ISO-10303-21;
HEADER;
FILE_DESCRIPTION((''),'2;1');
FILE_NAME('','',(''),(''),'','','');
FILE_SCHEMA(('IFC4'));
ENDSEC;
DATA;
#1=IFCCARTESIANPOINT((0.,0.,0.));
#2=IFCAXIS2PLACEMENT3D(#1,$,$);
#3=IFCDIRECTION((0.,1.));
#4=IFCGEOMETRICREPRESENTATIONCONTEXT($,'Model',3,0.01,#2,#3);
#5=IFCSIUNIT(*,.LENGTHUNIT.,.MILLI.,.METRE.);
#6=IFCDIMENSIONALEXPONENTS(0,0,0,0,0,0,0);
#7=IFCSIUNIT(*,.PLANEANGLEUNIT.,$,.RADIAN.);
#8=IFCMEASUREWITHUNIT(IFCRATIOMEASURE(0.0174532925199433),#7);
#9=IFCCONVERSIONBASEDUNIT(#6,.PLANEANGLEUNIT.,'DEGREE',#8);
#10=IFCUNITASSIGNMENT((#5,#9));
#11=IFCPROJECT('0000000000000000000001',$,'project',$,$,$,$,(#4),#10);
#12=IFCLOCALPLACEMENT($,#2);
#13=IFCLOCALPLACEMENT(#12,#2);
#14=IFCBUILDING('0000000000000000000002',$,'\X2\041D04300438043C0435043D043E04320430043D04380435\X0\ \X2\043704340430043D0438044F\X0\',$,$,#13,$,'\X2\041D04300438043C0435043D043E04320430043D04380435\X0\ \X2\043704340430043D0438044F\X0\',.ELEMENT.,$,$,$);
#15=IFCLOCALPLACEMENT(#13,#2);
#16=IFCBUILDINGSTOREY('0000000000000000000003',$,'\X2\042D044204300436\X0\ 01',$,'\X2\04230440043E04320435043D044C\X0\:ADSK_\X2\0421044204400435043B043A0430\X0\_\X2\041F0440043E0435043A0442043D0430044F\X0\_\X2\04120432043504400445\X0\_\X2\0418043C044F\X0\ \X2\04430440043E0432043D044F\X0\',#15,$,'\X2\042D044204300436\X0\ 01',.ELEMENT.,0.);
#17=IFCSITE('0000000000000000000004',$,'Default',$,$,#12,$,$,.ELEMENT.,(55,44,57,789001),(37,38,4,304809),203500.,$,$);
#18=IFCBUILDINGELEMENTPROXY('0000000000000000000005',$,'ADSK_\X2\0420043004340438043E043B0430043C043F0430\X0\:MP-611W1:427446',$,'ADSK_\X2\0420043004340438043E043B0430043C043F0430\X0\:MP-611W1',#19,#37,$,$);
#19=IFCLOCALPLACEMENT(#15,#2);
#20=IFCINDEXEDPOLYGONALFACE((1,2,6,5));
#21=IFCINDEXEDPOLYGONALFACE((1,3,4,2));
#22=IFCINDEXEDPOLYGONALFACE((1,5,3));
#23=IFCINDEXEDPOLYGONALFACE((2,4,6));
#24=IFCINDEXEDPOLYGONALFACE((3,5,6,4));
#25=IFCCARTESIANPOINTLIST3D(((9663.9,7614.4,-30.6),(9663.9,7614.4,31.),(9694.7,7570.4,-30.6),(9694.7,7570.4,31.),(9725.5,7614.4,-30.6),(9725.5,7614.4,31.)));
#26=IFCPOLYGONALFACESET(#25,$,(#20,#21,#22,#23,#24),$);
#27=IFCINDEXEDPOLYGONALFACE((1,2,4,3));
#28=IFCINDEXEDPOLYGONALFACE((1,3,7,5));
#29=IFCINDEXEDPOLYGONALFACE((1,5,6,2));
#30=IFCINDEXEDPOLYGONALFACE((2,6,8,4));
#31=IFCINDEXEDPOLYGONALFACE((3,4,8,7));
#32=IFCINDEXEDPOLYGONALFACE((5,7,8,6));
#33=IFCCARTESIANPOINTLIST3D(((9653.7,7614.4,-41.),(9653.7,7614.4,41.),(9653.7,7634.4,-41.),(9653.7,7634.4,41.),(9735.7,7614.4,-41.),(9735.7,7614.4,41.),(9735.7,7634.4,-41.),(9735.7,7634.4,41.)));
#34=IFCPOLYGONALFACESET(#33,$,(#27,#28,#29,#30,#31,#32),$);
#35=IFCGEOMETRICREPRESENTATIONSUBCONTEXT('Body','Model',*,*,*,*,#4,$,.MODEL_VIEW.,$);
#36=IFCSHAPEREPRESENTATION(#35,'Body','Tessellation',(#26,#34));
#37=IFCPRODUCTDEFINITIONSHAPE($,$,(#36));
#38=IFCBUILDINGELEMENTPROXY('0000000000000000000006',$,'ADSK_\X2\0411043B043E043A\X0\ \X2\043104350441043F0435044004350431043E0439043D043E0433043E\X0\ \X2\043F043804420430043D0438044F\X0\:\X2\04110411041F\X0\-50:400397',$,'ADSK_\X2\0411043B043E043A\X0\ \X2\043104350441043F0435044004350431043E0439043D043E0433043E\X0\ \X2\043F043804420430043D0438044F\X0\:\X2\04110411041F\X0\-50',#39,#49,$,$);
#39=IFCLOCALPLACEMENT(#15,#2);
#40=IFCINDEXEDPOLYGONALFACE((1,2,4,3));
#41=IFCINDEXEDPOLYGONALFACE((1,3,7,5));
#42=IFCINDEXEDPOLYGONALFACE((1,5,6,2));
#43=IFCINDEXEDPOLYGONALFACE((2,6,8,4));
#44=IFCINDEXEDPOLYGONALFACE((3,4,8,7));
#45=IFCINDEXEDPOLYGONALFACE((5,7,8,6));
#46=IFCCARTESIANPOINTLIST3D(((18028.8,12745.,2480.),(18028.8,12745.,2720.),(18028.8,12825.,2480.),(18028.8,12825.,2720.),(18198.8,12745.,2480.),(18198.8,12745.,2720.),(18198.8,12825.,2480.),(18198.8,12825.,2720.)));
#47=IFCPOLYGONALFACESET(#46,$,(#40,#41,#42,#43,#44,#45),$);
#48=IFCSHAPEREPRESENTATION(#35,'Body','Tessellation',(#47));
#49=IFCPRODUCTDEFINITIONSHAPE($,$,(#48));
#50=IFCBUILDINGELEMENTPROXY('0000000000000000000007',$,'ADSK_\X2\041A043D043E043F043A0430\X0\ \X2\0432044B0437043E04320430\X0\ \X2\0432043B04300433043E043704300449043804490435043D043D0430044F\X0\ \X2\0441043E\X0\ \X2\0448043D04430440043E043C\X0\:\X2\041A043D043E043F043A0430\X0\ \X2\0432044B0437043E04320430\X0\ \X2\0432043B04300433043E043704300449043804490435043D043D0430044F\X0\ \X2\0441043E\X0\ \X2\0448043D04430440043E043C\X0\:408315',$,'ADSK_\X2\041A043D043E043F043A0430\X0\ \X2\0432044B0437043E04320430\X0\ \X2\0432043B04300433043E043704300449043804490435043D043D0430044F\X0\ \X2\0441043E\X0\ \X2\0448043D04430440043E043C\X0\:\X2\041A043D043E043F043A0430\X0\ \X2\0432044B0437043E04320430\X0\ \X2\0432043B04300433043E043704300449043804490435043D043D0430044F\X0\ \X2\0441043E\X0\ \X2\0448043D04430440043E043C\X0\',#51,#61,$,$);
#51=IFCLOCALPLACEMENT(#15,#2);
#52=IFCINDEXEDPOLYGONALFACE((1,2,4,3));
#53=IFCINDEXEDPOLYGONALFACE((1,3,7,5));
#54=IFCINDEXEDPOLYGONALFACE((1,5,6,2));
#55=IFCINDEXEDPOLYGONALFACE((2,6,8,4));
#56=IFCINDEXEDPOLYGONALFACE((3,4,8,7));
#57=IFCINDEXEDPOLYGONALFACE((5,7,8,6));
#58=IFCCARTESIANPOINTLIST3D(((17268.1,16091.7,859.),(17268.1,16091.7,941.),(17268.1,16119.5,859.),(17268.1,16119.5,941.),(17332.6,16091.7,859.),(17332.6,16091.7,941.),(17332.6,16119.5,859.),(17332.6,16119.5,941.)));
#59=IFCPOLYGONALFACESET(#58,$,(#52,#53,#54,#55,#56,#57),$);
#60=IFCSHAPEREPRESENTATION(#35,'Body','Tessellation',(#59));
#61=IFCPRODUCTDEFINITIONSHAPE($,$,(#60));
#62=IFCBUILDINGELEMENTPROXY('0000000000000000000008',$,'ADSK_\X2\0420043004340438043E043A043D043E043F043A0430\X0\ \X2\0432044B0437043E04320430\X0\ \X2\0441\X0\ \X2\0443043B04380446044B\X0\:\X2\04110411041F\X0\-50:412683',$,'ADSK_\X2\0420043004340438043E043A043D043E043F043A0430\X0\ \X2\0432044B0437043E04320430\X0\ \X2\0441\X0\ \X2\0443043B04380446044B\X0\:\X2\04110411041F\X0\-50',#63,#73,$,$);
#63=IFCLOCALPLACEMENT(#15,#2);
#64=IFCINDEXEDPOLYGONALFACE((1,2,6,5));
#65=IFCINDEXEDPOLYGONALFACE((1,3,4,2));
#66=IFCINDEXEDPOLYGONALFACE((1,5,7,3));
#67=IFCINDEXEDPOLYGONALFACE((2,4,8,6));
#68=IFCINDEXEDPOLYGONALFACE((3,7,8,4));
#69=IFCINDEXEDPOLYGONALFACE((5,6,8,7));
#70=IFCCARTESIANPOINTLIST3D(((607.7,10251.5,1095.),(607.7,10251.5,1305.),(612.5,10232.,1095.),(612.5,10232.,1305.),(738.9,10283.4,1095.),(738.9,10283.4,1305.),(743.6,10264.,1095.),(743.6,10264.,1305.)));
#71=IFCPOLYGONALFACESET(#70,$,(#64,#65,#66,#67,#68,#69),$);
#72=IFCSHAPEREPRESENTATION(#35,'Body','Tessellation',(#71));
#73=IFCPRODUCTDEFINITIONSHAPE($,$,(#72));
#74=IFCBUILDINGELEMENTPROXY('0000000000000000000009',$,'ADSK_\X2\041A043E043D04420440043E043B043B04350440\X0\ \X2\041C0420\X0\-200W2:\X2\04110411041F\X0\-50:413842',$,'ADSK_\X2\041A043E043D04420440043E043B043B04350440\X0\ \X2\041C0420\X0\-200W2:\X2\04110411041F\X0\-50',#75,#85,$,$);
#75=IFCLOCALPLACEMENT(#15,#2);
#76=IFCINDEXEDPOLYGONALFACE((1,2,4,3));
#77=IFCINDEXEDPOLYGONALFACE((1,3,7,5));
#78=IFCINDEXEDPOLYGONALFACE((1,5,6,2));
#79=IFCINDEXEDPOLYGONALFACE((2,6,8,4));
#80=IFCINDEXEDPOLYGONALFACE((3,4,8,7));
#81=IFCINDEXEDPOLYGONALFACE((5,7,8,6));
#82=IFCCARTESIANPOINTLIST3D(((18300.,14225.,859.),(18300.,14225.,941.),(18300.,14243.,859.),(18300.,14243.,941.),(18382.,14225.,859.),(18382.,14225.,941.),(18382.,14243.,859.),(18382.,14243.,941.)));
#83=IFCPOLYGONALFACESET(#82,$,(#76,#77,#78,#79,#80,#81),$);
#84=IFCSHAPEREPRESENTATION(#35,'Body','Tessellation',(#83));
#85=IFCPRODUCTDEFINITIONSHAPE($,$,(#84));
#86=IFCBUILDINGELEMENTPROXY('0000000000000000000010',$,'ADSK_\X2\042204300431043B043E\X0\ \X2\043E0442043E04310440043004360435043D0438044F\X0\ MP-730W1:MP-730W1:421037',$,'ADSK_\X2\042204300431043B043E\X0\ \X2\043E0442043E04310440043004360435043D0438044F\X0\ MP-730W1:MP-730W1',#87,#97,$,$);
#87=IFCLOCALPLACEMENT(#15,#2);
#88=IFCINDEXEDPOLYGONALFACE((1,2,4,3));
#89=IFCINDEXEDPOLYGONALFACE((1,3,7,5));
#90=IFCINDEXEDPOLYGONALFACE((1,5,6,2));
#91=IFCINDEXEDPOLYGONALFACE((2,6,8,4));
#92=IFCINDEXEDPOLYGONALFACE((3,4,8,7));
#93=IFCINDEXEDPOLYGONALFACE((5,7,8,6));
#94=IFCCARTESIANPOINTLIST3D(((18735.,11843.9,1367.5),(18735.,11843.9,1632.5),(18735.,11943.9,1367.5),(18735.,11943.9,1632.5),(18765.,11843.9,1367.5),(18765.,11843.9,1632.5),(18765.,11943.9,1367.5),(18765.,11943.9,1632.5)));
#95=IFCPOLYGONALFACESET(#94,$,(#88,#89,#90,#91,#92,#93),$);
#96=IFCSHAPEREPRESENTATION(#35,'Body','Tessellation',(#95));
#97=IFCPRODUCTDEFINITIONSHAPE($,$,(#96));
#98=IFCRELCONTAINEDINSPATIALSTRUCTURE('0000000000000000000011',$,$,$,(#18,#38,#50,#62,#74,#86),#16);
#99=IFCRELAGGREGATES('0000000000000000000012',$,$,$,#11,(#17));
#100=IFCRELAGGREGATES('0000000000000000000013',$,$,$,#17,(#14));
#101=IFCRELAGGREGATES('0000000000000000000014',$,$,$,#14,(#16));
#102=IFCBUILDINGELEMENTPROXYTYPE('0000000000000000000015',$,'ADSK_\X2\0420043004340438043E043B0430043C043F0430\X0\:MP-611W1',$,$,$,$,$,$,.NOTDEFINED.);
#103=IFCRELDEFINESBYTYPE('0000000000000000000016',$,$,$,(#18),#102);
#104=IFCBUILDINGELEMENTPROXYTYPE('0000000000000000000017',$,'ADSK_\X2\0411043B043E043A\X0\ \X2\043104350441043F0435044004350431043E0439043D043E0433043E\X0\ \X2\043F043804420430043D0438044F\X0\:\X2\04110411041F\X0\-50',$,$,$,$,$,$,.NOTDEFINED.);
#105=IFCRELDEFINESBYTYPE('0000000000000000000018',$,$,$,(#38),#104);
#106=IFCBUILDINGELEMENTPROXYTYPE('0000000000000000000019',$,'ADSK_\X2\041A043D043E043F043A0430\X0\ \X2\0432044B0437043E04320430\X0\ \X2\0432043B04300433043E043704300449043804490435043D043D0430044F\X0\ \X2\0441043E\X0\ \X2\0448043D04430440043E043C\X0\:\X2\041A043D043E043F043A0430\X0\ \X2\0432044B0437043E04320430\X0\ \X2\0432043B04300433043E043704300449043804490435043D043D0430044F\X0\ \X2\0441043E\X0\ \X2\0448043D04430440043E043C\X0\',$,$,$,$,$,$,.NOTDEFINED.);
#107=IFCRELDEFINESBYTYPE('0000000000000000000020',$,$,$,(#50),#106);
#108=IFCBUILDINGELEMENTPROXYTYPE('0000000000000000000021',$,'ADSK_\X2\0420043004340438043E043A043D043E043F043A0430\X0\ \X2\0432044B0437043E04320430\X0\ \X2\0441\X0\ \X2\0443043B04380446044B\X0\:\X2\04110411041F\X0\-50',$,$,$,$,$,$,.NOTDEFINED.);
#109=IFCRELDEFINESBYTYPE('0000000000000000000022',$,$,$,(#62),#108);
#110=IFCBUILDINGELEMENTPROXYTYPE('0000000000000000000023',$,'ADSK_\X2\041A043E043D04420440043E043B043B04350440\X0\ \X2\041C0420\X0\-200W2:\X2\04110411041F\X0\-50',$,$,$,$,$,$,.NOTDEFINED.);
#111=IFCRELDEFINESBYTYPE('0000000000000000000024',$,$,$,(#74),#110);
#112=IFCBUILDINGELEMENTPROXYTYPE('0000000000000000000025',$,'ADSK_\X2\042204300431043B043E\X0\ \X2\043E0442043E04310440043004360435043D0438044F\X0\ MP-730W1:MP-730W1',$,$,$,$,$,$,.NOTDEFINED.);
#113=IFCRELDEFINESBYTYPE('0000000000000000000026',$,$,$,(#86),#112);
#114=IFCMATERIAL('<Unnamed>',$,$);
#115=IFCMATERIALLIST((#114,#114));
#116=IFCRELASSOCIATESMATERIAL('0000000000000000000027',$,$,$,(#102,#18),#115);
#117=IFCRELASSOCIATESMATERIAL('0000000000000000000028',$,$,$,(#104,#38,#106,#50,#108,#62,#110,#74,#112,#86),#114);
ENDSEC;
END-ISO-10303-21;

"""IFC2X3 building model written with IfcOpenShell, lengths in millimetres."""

from ifc_helpers import new_model, entity, si_unit, converted_unit, direction, frame, origin, origin_2d_with_axis, place, context, subcontext, project, spatial, polyline, rectangle, outline, extrude, source, transform, mapped, material, material_list, type_object, type_shapes, element, save


model = new_model("IFC2X3")

# Units and contexts
model_context = context("Model", 3, precision=0.01, world=origin(), true_north=direction((0.0, 1.0)))
body_context = subcontext(model_context, "Body", "Model", "MODEL_VIEW")
ifc_project = project(units=[si_unit("LENGTHUNIT", "METRE", prefix="MILLI"), converted_unit("PLANEANGLEUNIT", "DEGREE", entity("IfcRatioMeasure", 0.0174532925199433), si_unit("PLANEANGLEUNIT", "RADIAN"), dimensions=[0, 0, 0, 0, 0, 0, 0])], contexts=[model_context])

# Site, building, storey
site_placement = place(None, origin())
site = spatial("IfcSite", under=ifc_project, at=site_placement, Name="Default", CompositionType="ELEMENT", RefLatitude=(55, 44, 57, 789001), RefLongitude=(37, 38, 4, 304809), RefElevation=203500.0)
building_placement = place(site_placement, origin())
building = spatial("IfcBuilding", under=site, at=building_placement, Name="Наименование здания", LongName="Наименование здания", CompositionType="ELEMENT")
storey_placement = place(building_placement, origin())
storey = spatial("IfcBuildingStorey", under=building, at=storey_placement, Name="Этаж 01", ObjectType="Уровень:ADSK_Стрелка_Проектная_Вверх_Имя уровня", LongName="Этаж 01", CompositionType="ELEMENT", Elevation=0.0)

# Building element proxies
ifc_material_1 = material(Name="<Unnamed>")
ifc_material_list_1 = material_list([ifc_material_1, ifc_material_1])
shared_shape_1 = source(origin(), body_context, "Body", "SweptSolid", [
    extrude(outline(polyline([(-30.8, -14.7), (30.8, -14.7), (0.0, 29.3), (-30.8, -14.7)])), frame((0.0, -2.7, -30.6), z_axis=(0.0, 0.0, 1.0), x_axis=(-1.0, 0.0, 0.0)), (0.0, 0.0, 1.0), 61.6),
    extrude(rectangle(XDim=82.0, YDim=20.0, at=origin_2d_with_axis()), frame((0.0, 22.0, -41.0), z_axis=(0.0, 0.0, 1.0), x_axis=(-1.0, 0.0, 0.0)), (0.0, 0.0, 1.0), 82.0),
])
building_element_proxy_type_1 = type_object("IfcBuildingElementProxyType", Name="ADSK_Радиолампа:MP-611W1", PredefinedType="NOTDEFINED", material=ifc_material_list_1)
type_shapes(building_element_proxy_type_1, [shared_shape_1])
proxy_1_placement = place(storey_placement, frame((9694.7, 7602.4, 0.0)))
element("IfcBuildingElementProxy", 1, at=proxy_1_placement, inside=storey, type_object=building_element_proxy_type_1, material=ifc_material_list_1, Name="ADSK_Радиолампа:MP-611W1:427446", ObjectType="ADSK_Радиолампа:MP-611W1", context=body_context, shape_type="MappedRepresentation", body=[
    mapped(shared_shape_1, transform((0.0, 0.0, 0.0), scale=1.0)),
])
building_element_proxy_type_2 = type_object("IfcBuildingElementProxyType", Name="ADSK_Блок бесперебойного питания:ББП-50", PredefinedType="NOTDEFINED", material=ifc_material_1)
shared_shape_2 = source(origin(), body_context, "Body", "SweptSolid", [
    extrude(rectangle(XDim=170.0, YDim=80.0, at=origin_2d_with_axis()), frame((0.0, -8.0, -120.0), z_axis=(0.0, 0.0, 1.0), x_axis=(-1.0, 0.0, 0.0)), (0.0, 0.0, 1.0), 240.0),
])
type_shapes(building_element_proxy_type_2, [shared_shape_2])
proxy_2_placement = place(storey_placement, frame((18113.8, 12793.0, 2600.0)))
element("IfcBuildingElementProxy", 2, at=proxy_2_placement, inside=storey, type_object=building_element_proxy_type_2, material=ifc_material_1, Name="ADSK_Блок бесперебойного питания:ББП-50:400397", ObjectType="ADSK_Блок бесперебойного питания:ББП-50", context=body_context, shape_type="MappedRepresentation", body=[
    mapped(shared_shape_2, transform((0.0, 0.0, 0.0), scale=1.0)),
])
building_element_proxy_type_3 = type_object("IfcBuildingElementProxyType", Name="ADSK_Кнопка вызова влагозащищенная со шнуром:Кнопка вызова влагозащищенная со шнуром", PredefinedType="NOTDEFINED", material=ifc_material_1)
shared_shape_3 = source(origin(), body_context, "Body", "SweptSolid", [
    extrude(rectangle(XDim=64.5, YDim=27.8, at=origin_2d_with_axis()), frame((32.2, 13.9, 0.0), z_axis=(0.0, 0.0, 1.0), x_axis=(-1.0, 0.0, 0.0)), (0.0, 0.0, 1.0), 82.0),
])
type_shapes(building_element_proxy_type_3, [shared_shape_3])
proxy_3_placement = place(storey_placement, frame((17268.1, 16091.7, 859.0)))
element("IfcBuildingElementProxy", 3, at=proxy_3_placement, inside=storey, type_object=building_element_proxy_type_3, material=ifc_material_1, Name="ADSK_Кнопка вызова влагозащищенная со шнуром:Кнопка вызова влагозащищенная со шнуром:408315", ObjectType="ADSK_Кнопка вызова влагозащищенная со шнуром:Кнопка вызова влагозащищенная со шнуром", context=body_context, shape_type="MappedRepresentation", body=[
    mapped(shared_shape_3, transform((0.0, 0.0, 0.0), scale=1.0)),
])
building_element_proxy_type_4 = type_object("IfcBuildingElementProxyType", Name="ADSK_Радиокнопка вызова с улицы:ББП-50", PredefinedType="NOTDEFINED", material=ifc_material_1)
shared_shape_4 = source(origin(), body_context, "Body", "SweptSolid", [
    extrude(rectangle(XDim=135.0, YDim=20.0, at=origin_2d_with_axis()), frame((67.5, 10.0, 0.0), z_axis=(0.0, 0.0, 1.0), x_axis=(-1.0, 0.0, 0.0)), (0.0, 0.0, 1.0), 210.0),
])
type_shapes(building_element_proxy_type_4, [shared_shape_4])
proxy_4_placement = place(storey_placement, frame((612.5, 10232.0, 1095.0), z_axis=(0.0, 0.0, 1.0), x_axis=(0.971553, 0.236822, 0.0)))
element("IfcBuildingElementProxy", 4, at=proxy_4_placement, inside=storey, type_object=building_element_proxy_type_4, material=ifc_material_1, Name="ADSK_Радиокнопка вызова с улицы:ББП-50:412683", ObjectType="ADSK_Радиокнопка вызова с улицы:ББП-50", context=body_context, shape_type="MappedRepresentation", body=[
    mapped(shared_shape_4, transform((0.0, 0.0, 0.0), scale=1.0)),
])
building_element_proxy_type_5 = type_object("IfcBuildingElementProxyType", Name="ADSK_Контроллер МР-200W2:ББП-50", PredefinedType="NOTDEFINED", material=ifc_material_1)
shared_shape_5 = source(origin(), body_context, "Body", "SweptSolid", [
    extrude(rectangle(XDim=82.0, YDim=18.0, at=origin_2d_with_axis()), frame((41.0, 9.0, 0.0), z_axis=(0.0, 0.0, 1.0), x_axis=(-1.0, 0.0, 0.0)), (0.0, 0.0, 1.0), 82.0),
])
type_shapes(building_element_proxy_type_5, [shared_shape_5])
proxy_5_placement = place(storey_placement, frame((18382.0, 14243.0, 859.0), z_axis=(0.0, 0.0, 1.0), x_axis=(-1.0, 0.0, 0.0)))
element("IfcBuildingElementProxy", 5, at=proxy_5_placement, inside=storey, type_object=building_element_proxy_type_5, material=ifc_material_1, Name="ADSK_Контроллер МР-200W2:ББП-50:413842", ObjectType="ADSK_Контроллер МР-200W2:ББП-50", context=body_context, shape_type="MappedRepresentation", body=[
    mapped(shared_shape_5, transform((0.0, 0.0, 0.0), scale=1.0)),
])
building_element_proxy_type_6 = type_object("IfcBuildingElementProxyType", Name="ADSK_Табло отображения MP-730W1:MP-730W1", PredefinedType="NOTDEFINED", material=ifc_material_1)
shared_shape_6 = source(origin(), body_context, "Body", "SweptSolid", [
    extrude(rectangle(XDim=100.0, YDim=30.0, at=origin_2d_with_axis()), frame((50.0, 15.0, 0.0), z_axis=(0.0, 0.0, 1.0), x_axis=(-1.0, 0.0, 0.0)), (0.0, 0.0, 1.0), 265.0),
])
type_shapes(building_element_proxy_type_6, [shared_shape_6])
proxy_6_placement = place(storey_placement, frame((18735.0, 11943.9, 1367.5), z_axis=(0.0, 0.0, 1.0), x_axis=(0.0, -1.0, 0.0)))
element("IfcBuildingElementProxy", 6, at=proxy_6_placement, inside=storey, type_object=building_element_proxy_type_6, material=ifc_material_1, Name="ADSK_Табло отображения MP-730W1:MP-730W1:421037", ObjectType="ADSK_Табло отображения MP-730W1:MP-730W1", context=body_context, shape_type="MappedRepresentation", body=[
    mapped(shared_shape_6, transform((0.0, 0.0, 0.0), scale=1.0)),
])

save(model, "model.ifc")
